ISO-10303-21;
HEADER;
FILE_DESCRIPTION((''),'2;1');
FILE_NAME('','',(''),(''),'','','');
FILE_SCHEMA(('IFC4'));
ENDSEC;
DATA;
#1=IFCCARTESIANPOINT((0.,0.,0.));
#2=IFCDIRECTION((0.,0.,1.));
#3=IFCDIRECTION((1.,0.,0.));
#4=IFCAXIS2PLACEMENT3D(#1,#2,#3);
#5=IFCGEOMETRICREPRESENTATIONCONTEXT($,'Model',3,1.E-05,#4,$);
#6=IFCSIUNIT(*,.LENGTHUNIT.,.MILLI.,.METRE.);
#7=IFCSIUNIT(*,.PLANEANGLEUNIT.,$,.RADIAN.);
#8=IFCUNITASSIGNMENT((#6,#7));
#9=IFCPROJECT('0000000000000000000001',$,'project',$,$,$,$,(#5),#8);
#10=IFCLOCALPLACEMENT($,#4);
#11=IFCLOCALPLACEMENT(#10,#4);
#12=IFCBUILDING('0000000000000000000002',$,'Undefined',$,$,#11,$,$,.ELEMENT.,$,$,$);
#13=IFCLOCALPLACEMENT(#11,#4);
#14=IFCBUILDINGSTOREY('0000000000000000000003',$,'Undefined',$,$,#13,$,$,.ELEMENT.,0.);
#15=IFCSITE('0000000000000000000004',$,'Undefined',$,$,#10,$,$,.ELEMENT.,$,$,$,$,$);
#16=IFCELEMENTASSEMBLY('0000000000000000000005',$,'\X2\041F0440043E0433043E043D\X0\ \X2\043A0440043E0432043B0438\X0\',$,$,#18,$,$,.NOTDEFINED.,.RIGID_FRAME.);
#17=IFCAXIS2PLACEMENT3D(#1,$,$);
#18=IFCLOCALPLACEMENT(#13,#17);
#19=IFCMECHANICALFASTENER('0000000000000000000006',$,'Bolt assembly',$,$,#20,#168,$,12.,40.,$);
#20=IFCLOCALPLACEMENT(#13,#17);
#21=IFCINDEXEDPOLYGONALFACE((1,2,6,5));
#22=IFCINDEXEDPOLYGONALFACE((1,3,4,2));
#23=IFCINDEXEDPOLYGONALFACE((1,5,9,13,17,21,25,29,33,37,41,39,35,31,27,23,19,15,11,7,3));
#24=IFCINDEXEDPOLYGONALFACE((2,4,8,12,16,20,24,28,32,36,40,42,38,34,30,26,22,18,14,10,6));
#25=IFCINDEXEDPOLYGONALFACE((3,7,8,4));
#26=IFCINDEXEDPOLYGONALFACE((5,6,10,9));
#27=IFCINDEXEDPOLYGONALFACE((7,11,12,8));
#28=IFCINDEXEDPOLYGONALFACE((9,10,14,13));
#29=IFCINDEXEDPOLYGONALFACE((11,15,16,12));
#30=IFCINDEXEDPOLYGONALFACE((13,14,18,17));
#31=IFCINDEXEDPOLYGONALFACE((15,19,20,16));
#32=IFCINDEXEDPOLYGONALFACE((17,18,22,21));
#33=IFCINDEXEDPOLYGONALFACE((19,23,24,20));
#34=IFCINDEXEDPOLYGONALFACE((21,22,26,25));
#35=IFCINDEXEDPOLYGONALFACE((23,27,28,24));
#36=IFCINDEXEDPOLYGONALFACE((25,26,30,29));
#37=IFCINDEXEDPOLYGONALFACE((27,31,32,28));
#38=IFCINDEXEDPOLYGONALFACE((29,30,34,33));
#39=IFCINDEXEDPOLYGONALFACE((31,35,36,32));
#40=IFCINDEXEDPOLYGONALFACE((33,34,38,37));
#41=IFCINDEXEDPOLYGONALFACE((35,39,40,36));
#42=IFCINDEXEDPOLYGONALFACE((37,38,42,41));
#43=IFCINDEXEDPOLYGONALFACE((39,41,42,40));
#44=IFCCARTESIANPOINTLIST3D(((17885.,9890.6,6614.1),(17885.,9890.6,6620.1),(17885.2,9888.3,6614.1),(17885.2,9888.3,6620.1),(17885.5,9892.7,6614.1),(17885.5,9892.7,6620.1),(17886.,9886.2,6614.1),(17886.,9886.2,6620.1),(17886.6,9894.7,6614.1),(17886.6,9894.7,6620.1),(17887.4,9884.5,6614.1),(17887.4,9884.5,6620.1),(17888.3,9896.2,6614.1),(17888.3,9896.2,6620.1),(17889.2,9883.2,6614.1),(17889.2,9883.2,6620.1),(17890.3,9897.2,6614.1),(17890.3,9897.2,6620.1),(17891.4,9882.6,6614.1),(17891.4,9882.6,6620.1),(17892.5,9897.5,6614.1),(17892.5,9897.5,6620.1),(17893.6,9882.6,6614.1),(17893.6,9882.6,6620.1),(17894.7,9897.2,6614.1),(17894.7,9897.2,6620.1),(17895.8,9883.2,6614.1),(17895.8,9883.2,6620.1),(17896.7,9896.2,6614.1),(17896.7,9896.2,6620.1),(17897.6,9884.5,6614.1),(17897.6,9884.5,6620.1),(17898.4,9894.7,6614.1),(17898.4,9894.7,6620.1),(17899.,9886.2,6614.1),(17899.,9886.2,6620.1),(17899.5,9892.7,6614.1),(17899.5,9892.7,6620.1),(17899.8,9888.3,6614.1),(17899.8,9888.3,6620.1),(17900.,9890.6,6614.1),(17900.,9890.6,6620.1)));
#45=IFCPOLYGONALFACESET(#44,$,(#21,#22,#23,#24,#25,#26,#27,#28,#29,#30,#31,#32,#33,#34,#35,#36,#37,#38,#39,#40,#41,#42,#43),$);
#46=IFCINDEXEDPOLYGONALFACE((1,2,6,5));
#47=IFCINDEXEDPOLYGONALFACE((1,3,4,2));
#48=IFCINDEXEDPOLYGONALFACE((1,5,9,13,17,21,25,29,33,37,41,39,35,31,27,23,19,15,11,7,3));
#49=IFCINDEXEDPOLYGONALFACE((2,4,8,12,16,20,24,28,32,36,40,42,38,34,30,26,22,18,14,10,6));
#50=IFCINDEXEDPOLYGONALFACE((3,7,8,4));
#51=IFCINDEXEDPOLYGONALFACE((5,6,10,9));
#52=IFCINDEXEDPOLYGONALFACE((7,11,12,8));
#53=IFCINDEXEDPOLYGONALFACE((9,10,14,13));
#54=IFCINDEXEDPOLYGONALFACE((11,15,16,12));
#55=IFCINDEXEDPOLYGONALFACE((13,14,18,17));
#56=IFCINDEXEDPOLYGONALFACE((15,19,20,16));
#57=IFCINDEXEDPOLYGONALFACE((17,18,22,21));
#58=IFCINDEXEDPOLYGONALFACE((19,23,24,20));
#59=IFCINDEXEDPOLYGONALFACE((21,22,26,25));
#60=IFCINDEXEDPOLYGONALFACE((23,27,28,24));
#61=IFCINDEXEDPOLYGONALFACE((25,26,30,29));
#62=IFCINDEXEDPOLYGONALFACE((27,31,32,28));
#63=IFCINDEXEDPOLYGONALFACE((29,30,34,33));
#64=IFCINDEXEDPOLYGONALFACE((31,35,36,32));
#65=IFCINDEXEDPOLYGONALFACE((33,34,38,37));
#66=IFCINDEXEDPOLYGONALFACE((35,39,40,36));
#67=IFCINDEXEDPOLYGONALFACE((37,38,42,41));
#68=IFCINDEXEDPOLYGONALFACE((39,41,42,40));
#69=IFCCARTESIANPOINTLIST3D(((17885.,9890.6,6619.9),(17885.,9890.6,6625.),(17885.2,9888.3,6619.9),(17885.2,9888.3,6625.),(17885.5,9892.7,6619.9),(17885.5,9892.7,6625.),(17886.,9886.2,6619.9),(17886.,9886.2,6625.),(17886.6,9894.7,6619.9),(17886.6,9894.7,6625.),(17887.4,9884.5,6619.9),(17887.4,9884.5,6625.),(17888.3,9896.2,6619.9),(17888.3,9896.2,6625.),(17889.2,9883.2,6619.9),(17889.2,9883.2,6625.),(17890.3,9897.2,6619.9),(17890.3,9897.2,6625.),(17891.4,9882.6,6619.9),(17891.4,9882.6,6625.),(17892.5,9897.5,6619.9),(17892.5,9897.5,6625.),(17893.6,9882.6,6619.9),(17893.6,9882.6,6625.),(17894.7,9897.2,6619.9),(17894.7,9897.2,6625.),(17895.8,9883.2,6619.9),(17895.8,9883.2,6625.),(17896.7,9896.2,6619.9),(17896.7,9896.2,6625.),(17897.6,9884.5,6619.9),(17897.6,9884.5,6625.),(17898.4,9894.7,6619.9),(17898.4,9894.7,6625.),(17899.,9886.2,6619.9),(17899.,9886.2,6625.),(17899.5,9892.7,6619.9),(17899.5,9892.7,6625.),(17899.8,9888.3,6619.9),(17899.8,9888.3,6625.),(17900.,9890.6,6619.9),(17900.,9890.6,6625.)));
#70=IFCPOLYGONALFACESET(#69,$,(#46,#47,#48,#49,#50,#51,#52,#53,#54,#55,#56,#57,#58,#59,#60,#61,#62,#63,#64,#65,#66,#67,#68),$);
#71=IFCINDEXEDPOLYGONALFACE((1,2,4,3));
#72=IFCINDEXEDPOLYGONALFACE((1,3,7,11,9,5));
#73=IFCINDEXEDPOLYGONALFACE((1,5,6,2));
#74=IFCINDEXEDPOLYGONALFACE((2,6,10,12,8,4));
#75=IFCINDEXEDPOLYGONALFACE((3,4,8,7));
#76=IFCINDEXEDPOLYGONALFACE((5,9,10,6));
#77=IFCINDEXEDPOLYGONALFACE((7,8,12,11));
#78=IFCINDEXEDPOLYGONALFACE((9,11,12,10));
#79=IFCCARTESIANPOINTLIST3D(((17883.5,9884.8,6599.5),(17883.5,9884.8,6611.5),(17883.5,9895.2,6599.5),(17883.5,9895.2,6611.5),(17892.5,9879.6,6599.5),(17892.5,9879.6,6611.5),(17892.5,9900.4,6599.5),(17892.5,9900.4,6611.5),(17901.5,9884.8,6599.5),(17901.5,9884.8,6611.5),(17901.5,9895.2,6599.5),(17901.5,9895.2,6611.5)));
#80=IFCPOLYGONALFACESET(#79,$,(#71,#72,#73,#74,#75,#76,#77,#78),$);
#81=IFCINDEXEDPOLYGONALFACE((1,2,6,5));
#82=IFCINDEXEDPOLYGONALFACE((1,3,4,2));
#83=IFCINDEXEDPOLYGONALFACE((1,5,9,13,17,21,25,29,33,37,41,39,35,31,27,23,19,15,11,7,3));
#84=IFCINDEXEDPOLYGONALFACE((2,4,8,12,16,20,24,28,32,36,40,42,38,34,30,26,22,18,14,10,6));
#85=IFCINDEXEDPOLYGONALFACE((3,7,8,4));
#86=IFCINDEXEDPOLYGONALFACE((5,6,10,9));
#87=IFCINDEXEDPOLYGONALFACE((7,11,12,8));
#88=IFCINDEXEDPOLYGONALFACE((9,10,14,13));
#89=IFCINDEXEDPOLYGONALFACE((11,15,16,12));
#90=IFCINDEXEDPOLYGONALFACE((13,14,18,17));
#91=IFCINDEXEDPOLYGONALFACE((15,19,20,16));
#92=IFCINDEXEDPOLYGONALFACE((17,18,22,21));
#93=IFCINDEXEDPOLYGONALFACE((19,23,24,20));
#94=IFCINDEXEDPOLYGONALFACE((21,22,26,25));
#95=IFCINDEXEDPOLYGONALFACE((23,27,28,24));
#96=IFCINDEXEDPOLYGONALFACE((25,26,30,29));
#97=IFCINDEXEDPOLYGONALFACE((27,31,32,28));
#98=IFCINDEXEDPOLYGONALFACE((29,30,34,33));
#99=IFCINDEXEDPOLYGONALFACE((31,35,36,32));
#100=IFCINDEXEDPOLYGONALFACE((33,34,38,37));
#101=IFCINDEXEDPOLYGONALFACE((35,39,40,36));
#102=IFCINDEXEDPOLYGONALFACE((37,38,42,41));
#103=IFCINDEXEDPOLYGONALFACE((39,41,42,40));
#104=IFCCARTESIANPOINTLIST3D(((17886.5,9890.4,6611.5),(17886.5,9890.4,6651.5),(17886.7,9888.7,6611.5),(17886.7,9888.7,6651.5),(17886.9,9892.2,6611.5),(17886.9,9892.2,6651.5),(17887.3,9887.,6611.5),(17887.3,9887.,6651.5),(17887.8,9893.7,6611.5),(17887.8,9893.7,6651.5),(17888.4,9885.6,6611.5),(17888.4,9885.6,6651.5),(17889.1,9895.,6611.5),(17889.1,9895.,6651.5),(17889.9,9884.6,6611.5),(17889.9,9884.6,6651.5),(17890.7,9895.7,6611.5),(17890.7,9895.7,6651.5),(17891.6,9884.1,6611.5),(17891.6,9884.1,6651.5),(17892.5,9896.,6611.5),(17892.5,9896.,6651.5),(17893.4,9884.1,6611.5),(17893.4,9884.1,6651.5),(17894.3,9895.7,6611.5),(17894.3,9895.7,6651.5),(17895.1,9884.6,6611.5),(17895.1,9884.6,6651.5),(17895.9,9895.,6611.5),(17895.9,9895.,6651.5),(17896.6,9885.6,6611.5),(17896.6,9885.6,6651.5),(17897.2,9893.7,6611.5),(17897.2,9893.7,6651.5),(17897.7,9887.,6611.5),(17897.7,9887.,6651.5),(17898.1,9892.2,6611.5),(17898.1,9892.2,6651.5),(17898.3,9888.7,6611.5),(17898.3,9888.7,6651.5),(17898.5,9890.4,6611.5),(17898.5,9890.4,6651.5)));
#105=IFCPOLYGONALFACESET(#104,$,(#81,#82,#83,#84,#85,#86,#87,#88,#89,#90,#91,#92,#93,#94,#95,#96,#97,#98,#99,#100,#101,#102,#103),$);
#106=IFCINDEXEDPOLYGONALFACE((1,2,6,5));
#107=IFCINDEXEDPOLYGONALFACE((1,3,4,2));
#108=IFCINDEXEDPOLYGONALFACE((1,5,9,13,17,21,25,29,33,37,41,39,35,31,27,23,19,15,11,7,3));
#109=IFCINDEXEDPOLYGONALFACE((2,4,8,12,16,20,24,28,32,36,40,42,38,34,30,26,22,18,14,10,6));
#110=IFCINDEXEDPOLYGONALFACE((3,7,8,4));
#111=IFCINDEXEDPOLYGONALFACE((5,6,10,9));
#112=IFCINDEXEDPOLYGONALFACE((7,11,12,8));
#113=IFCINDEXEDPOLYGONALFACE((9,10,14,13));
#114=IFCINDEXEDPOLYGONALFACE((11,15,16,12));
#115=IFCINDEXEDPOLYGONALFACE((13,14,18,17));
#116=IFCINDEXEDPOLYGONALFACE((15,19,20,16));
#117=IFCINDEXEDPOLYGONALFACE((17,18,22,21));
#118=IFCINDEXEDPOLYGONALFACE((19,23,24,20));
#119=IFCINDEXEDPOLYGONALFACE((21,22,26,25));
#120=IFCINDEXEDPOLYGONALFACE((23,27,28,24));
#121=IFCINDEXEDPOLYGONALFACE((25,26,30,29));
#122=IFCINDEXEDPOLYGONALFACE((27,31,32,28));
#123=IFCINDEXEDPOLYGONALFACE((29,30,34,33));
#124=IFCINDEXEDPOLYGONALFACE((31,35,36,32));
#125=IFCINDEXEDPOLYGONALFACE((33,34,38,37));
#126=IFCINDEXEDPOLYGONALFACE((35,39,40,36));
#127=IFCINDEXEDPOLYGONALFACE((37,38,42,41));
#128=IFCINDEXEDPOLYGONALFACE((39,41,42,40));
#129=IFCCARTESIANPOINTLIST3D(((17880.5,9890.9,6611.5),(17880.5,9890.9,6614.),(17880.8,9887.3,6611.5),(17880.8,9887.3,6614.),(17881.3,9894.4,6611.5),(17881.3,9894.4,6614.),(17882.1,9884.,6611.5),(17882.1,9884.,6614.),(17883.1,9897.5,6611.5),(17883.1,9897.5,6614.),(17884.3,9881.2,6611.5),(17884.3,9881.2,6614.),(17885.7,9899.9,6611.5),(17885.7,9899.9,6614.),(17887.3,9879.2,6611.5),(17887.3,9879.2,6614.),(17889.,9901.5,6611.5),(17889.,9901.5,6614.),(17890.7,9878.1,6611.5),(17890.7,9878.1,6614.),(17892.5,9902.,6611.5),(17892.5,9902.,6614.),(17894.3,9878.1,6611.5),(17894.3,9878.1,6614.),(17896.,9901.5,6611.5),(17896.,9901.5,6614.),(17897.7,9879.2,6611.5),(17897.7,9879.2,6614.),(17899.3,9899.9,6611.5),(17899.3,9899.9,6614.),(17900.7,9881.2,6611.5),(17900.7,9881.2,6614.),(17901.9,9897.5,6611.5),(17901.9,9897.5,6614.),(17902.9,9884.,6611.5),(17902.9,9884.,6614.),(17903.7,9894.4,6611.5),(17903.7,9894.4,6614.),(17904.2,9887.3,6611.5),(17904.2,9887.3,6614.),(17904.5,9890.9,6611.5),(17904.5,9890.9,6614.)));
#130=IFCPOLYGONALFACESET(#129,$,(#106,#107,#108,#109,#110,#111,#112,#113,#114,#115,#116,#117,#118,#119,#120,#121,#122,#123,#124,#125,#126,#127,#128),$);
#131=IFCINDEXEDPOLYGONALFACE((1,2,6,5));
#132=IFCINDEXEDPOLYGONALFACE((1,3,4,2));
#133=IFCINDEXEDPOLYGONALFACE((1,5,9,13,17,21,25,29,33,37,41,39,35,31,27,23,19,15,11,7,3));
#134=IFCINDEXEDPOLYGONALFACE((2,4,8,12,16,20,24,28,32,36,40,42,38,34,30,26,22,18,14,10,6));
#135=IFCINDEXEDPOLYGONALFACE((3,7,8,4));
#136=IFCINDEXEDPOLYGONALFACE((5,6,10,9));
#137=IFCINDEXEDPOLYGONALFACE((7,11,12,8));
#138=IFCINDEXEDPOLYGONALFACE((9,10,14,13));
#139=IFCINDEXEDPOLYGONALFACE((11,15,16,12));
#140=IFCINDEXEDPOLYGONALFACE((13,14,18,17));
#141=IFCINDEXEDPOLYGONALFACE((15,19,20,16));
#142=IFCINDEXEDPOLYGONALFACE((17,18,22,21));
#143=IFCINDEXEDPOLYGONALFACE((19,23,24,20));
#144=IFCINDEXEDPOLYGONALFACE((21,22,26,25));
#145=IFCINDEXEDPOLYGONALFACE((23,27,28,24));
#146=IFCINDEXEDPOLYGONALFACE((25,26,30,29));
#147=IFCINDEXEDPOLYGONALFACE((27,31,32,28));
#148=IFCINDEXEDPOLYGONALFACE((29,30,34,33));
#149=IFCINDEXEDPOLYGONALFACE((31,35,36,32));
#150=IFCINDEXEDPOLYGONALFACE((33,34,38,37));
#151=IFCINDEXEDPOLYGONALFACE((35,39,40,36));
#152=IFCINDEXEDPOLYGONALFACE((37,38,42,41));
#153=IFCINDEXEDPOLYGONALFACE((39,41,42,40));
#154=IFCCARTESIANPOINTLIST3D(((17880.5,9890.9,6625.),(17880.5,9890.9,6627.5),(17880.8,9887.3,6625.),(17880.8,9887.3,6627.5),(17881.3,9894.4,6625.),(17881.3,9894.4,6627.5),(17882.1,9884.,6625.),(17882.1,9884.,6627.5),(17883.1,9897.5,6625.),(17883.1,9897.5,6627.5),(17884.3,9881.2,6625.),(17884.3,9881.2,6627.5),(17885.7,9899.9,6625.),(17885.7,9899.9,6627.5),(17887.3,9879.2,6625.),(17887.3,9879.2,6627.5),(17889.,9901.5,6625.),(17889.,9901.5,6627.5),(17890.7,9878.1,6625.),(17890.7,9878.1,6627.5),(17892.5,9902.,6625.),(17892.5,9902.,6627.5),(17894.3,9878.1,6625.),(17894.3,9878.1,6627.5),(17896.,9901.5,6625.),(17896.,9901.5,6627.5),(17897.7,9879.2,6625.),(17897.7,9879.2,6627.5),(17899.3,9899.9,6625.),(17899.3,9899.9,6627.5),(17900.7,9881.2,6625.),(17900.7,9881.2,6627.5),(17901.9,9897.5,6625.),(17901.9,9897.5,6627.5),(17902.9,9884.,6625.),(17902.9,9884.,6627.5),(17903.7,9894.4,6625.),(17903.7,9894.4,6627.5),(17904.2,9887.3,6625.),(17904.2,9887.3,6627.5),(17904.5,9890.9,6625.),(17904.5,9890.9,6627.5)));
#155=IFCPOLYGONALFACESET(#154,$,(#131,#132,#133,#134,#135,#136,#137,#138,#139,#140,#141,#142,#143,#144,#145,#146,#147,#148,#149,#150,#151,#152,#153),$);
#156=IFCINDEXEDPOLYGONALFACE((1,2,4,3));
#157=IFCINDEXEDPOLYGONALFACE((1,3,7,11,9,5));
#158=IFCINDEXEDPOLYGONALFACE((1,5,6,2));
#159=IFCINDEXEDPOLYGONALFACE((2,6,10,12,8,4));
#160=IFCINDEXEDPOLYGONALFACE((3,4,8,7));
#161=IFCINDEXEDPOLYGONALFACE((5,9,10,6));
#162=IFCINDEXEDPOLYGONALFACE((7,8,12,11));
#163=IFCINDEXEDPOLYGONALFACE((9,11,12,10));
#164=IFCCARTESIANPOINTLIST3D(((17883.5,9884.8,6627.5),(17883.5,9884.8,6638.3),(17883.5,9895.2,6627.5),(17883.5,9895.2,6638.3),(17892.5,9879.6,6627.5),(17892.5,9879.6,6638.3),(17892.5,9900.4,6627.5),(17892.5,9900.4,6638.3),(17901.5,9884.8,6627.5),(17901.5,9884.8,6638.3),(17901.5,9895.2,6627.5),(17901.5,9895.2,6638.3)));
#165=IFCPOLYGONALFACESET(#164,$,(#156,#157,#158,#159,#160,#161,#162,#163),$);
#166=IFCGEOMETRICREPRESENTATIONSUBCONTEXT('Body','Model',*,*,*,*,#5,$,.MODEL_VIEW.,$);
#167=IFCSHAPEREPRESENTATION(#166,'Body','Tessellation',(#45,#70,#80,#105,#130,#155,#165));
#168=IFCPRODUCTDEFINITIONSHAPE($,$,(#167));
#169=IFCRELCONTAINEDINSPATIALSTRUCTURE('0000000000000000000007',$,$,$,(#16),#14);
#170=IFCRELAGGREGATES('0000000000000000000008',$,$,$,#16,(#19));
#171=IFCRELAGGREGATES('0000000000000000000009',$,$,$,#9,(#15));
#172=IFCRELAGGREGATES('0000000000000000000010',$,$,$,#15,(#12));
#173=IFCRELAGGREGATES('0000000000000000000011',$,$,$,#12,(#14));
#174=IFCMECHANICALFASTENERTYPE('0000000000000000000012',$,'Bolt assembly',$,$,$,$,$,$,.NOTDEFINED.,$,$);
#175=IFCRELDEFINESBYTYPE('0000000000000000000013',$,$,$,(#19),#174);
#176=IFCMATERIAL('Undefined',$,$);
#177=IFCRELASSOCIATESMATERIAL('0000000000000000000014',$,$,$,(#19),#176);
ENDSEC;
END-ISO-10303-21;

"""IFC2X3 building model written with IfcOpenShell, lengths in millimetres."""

from ifc_helpers import new_model, si_unit, frame, origin_with_axes, origin_2d_with_axis, place, context, subcontext, project, spatial, polyline, circle, outline, extrude, source, transform, mapped, material, type_object, element, aggregate, save


model = new_model("IFC2X3")

# Units and contexts
model_context = context("Model", 3, precision=1e-05, world=origin_with_axes())
body_context = subcontext(model_context, "Body", "Model", "MODEL_VIEW")
ifc_project = project(units=[si_unit("LENGTHUNIT", "METRE", prefix="MILLI"), si_unit("PLANEANGLEUNIT", "RADIAN")], contexts=[model_context])

# Site, building, storey
site_placement = place(None, origin_with_axes())
site = spatial("IfcSite", under=ifc_project, at=site_placement, Name="Undefined", CompositionType="ELEMENT")
building_placement = place(site_placement, origin_with_axes())
building = spatial("IfcBuilding", under=site, at=building_placement, Name="Undefined", CompositionType="ELEMENT")
storey_placement = place(building_placement, origin_with_axes())
storey = spatial("IfcBuildingStorey", under=building, at=storey_placement, Name="Undefined", CompositionType="ELEMENT", Elevation=0.0)

# Element assembly
assembly_1_placement = place(storey_placement, origin_with_axes())
assembly_1 = element("IfcElementAssembly", 1, at=assembly_1_placement, inside=storey, Name="Прогон кровли", AssemblyPlace="NOTDEFINED", PredefinedType="RIGID_FRAME")

# Mechanical fastener
ifc_material_1 = material(Name="Undefined")
mechanical_fastener_type = type_object("IfcMechanicalFastenerType", Name="Bolt assembly")
shared_shape_1 = source(origin_with_axes(), body_context, "Body", "SweptSolid", [
    extrude(circle(Radius=7.5, at=origin_2d_with_axis()), frame((0.0, -5.9, 0.0), z_axis=(0.0, 1.0, 0.0), x_axis=(1.0, 0.0, 0.0)), (0.0, 0.0, 1.0), 6.0),
    extrude(circle(Radius=7.5, at=origin_2d_with_axis()), frame((0.0, -0.1, 0.0), z_axis=(0.0, 1.0, 0.0), x_axis=(1.0, 0.0, 0.0)), (0.0, 0.0, 1.0), 5.1),
    extrude(outline(polyline([(10.4, 0.0), (5.2, 9.0), (-5.2, 9.0), (-10.4, 0.0), (-5.2, -9.0), (5.2, -9.0), (10.4, 0.0)])), frame((0.0, -20.5, 0.0), z_axis=(0.0, 1.0, 0.0), x_axis=(1.0, 0.0, 0.0)), (0.0, 0.0, 1.0), 12.0),
    extrude(circle(Radius=6.0, at=origin_2d_with_axis()), frame((0.0, -8.5, 0.0), z_axis=(0.0, 1.0, 0.0), x_axis=(1.0, 0.0, 0.0)), (0.0, 0.0, 1.0), 40.0),
    extrude(circle(Radius=12.0, at=origin_2d_with_axis()), frame((0.0, -8.5, 0.0), z_axis=(0.0, 1.0, 0.0), x_axis=(1.0, 0.0, 0.0)), (0.0, 0.0, 1.0), 2.5),
    extrude(circle(Radius=12.0, at=origin_2d_with_axis()), frame((0.0, 5.0, 0.0), z_axis=(0.0, 1.0, 0.0), x_axis=(1.0, 0.0, 0.0)), (0.0, 0.0, 1.0), 2.5),
    extrude(outline(polyline([(10.4, 0.0), (5.2, 9.0), (-5.2, 9.0), (-10.4, 0.0), (-5.2, -9.0), (5.2, -9.0), (10.4, 0.0)])), frame((0.0, 7.5, 0.0), z_axis=(0.0, 1.0, 0.0), x_axis=(1.0, 0.0, 0.0)), (0.0, 0.0, 1.0), 10.8),
])
mechanical_fastener_1_placement = place(assembly_1_placement, frame((17892.5, 9890.0, 6620.0), z_axis=(1.0, 0.0, 0.0), x_axis=(0.0, 1.0, 0.0)))
mechanical_fastener_1 = element("IfcMechanicalFastener", 2, at=mechanical_fastener_1_placement, type_object=mechanical_fastener_type, material=ifc_material_1, Name="Bolt assembly", NominalDiameter=12.0, NominalLength=40.0, context=body_context, shape_type="MappedRepresentation", body=[
    mapped(shared_shape_1, transform((0.0, 0.0, 0.0))),
])
aggregate(assembly_1, [mechanical_fastener_1])

save(model, "model.ifc")
